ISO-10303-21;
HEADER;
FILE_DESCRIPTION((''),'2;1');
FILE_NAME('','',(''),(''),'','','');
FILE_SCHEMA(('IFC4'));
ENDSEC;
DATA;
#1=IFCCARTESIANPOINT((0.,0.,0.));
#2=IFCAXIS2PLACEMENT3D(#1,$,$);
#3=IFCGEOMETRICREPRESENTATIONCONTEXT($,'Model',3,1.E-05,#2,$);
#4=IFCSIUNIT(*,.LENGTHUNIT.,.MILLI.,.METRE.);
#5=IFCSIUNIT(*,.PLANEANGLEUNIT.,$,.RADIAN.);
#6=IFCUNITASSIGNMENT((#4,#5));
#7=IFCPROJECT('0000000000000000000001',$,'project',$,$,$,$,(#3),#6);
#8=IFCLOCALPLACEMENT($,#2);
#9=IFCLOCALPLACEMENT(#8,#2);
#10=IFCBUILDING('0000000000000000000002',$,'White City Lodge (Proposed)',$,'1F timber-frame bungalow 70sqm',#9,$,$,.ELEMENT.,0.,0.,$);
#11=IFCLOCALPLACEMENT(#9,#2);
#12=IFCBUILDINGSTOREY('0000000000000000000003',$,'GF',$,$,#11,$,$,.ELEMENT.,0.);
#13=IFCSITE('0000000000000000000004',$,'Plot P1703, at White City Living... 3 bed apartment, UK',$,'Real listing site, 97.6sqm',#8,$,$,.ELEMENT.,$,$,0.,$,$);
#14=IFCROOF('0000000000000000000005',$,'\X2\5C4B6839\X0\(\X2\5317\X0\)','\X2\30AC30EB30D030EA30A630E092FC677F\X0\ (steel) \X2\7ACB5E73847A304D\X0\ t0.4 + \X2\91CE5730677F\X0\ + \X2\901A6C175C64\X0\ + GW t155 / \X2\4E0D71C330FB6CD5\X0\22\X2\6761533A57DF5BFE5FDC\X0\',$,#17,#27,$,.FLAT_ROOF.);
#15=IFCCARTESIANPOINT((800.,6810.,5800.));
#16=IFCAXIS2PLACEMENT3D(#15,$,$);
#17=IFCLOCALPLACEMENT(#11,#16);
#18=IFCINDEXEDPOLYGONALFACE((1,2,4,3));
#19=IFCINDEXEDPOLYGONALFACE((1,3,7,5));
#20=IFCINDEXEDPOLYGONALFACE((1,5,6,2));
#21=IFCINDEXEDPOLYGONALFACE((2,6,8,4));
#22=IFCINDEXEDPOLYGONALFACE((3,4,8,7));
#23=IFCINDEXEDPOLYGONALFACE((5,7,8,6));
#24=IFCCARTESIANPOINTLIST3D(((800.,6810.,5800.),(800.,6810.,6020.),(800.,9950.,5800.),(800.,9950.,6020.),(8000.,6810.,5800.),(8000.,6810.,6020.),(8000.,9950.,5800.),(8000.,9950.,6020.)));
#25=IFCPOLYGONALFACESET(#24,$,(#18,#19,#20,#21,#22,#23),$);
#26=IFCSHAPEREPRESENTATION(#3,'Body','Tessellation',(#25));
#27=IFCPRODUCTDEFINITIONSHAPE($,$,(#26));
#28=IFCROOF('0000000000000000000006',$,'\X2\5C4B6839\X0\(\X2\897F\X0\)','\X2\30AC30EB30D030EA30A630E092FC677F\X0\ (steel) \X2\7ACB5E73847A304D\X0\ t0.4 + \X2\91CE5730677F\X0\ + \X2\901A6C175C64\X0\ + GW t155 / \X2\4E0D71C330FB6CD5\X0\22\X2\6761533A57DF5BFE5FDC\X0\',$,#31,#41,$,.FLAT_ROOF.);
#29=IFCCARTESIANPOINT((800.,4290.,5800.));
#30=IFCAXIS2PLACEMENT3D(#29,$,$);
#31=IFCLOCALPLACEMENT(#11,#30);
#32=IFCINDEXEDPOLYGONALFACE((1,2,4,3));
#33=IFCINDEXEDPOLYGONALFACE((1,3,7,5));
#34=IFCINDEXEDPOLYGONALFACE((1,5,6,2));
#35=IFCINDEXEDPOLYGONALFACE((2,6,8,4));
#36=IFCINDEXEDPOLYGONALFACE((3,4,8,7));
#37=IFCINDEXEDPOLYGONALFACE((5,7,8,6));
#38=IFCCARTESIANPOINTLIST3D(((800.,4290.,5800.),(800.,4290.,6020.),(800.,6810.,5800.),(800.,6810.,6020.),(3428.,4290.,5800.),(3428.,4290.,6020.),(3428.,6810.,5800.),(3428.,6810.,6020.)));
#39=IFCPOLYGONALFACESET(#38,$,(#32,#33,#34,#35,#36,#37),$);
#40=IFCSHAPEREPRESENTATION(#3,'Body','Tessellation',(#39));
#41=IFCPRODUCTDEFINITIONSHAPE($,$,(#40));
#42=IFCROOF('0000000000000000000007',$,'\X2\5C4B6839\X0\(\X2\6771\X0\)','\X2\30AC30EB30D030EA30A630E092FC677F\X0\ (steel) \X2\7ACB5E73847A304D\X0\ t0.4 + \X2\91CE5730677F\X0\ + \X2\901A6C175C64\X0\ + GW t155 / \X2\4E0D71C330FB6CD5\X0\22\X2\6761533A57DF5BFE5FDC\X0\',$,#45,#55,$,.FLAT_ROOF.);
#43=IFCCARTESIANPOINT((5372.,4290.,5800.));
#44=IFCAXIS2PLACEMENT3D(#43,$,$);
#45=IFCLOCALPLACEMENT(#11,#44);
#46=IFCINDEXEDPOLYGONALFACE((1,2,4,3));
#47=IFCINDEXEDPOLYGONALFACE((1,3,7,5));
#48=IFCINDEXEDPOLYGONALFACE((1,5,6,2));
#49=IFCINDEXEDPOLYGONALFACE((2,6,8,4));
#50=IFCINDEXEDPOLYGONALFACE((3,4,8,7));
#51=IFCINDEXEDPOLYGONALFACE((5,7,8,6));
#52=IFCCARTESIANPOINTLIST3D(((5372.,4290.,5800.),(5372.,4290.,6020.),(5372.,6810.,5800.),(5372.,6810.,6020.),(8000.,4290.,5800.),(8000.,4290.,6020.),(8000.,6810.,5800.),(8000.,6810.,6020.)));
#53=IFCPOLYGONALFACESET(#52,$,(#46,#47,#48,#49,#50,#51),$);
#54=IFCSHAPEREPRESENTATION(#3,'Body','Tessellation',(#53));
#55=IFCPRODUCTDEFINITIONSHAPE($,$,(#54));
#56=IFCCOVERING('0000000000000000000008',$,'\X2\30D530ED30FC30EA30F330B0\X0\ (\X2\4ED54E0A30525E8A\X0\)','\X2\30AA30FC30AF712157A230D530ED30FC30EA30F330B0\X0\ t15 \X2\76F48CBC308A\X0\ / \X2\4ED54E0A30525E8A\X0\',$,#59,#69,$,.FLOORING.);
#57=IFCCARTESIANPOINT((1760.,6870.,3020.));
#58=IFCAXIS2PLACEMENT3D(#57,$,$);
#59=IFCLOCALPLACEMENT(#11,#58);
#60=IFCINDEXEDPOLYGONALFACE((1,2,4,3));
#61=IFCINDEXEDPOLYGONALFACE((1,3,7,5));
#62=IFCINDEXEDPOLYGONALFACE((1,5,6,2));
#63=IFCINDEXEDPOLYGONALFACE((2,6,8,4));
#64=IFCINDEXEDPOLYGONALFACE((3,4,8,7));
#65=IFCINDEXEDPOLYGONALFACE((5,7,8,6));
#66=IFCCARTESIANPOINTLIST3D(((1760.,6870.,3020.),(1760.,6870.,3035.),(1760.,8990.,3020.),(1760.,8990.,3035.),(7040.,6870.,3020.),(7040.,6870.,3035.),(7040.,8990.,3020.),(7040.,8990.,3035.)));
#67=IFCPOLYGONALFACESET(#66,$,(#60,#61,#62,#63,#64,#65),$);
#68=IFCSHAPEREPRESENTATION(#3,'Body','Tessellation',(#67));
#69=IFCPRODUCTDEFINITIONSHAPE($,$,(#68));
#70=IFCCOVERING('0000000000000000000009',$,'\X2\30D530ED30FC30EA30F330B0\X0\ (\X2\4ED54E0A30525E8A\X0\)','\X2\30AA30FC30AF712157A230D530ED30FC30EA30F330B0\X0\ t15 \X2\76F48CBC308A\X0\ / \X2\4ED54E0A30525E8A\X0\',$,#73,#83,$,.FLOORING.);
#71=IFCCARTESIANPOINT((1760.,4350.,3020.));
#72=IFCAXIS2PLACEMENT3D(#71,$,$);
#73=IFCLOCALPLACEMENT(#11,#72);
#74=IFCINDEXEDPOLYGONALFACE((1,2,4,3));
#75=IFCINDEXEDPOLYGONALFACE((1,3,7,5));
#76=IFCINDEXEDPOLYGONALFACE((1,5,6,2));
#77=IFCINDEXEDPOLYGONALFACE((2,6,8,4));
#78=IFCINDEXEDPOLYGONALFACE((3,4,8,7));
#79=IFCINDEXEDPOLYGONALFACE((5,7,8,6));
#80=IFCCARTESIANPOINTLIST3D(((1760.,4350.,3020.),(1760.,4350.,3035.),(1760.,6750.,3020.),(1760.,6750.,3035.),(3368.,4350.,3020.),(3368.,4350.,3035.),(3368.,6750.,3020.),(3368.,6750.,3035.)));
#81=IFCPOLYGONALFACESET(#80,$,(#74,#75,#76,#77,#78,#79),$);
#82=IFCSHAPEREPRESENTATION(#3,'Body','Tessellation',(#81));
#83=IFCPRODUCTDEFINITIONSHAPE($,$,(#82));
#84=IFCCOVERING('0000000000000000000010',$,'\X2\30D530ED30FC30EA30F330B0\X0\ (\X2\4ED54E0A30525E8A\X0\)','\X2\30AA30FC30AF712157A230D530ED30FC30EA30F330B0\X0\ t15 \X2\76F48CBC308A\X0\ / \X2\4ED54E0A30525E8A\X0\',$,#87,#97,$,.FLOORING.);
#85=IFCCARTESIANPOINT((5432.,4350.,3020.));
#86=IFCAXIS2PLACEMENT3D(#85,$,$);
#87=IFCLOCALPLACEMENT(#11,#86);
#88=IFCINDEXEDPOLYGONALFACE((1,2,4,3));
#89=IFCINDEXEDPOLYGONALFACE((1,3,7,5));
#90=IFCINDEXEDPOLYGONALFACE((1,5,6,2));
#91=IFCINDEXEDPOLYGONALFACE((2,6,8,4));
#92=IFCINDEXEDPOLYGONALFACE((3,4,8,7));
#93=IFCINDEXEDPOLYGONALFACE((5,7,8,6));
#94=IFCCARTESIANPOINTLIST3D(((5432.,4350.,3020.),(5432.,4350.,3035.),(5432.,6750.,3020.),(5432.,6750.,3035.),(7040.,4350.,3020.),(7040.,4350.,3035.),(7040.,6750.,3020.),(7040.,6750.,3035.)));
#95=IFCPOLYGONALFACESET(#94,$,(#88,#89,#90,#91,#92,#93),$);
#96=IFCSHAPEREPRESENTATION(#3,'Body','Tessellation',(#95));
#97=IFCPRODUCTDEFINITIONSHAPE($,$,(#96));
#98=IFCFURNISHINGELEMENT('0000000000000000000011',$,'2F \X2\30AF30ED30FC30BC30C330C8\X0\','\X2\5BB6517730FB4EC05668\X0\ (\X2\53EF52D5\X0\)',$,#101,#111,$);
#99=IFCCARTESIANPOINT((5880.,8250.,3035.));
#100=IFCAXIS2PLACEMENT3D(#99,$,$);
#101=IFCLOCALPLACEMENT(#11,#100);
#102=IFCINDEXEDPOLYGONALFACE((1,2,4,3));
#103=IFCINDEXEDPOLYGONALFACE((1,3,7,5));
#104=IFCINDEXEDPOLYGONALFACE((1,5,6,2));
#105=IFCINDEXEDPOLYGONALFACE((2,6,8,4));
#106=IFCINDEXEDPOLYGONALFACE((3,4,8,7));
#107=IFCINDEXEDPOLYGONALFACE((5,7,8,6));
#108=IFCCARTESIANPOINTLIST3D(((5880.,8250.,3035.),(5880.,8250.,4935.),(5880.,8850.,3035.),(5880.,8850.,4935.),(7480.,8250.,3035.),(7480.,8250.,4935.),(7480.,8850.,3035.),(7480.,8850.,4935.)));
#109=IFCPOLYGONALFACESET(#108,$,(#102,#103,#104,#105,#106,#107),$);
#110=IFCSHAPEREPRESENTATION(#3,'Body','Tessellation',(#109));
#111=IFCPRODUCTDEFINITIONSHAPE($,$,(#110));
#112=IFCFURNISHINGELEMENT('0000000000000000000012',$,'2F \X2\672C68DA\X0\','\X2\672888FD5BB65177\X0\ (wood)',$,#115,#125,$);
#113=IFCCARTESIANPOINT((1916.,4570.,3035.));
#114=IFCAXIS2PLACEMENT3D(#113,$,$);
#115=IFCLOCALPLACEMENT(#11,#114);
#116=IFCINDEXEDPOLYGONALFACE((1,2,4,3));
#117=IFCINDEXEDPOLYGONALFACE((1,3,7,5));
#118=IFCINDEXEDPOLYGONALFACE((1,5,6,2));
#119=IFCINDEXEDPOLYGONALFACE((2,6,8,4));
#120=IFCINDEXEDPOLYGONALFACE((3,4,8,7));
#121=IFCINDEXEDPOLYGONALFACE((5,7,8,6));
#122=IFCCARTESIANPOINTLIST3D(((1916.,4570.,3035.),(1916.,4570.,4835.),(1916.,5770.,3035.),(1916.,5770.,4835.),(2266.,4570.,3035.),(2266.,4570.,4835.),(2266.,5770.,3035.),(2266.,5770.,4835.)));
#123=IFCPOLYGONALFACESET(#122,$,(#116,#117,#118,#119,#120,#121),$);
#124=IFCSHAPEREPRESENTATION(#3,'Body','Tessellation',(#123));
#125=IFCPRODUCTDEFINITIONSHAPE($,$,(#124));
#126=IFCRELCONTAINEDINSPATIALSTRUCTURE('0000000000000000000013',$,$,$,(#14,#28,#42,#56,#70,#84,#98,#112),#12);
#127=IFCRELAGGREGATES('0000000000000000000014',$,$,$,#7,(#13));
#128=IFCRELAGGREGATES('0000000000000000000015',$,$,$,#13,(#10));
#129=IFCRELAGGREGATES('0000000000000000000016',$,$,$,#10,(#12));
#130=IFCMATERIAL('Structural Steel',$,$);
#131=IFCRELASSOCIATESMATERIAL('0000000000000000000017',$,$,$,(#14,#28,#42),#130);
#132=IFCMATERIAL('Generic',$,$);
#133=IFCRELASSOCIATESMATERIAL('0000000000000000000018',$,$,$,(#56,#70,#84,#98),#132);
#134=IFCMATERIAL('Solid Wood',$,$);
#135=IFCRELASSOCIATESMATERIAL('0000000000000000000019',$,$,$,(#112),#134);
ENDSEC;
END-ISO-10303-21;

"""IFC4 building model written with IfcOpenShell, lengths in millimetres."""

from ifc_helpers import new_model, si_unit, frame, frame_2d, origin, place, context, project, spatial, rectangle, extrude, material, element, save


model = new_model("IFC4")

# Units and contexts
model_context = context("Model", 3, precision=1e-05, world=origin())
ifc_project = project(units=[si_unit("LENGTHUNIT", "METRE", prefix="MILLI"), si_unit("PLANEANGLEUNIT", "RADIAN")], contexts=[model_context])

# Site, building, storey
site_placement = place(None, origin())
site = spatial("IfcSite", under=ifc_project, at=site_placement, Name="Plot P1703, at White City Living... 3 bed apartment, UK", ObjectType="Real listing site, 97.6sqm", CompositionType="ELEMENT", RefElevation=0.0)
building_placement = place(site_placement, origin())
building = spatial("IfcBuilding", under=site, at=building_placement, Name="White City Lodge (Proposed)", ObjectType="1F timber-frame bungalow 70sqm", CompositionType="ELEMENT", ElevationOfRefHeight=0.0, ElevationOfTerrain=0.0)
storey_placement = place(building_placement, origin())
storey = spatial("IfcBuildingStorey", under=building, at=storey_placement, Name="GF", CompositionType="ELEMENT", Elevation=0.0)

# Shared definitions
ifc_material_1 = material(Name="Solid Wood")

# Shared definitions
ifc_material_2 = material(Name="Generic")

# Roofs
ifc_material_3 = material(Name="Structural Steel")
for number, where, name in (
    (1, (800.0, 6810.0, 5800.0), "屋根(北)"),
):
    element("IfcRoof", number, at=place(storey_placement, frame(where)), inside=storey, material=ifc_material_3, Name=name, Description="ガルバリウム鋼板 (steel) 立平葺き t0.4 + 野地板 + 通気層 + GW t155 / 不燃・法22条区域対応", PredefinedType="FLAT_ROOF", context=model_context, shape_type="SweptSolid", body=[
        extrude(rectangle(XDim=7200.0, YDim=3140.0, at=frame_2d((3600.0, 1570.0))), frame((800.0, 6810.0, 5800.0)), (0.0, 0.0, 1.0), 220.0),
    ])
roof_1_placement = place(storey_placement, frame((800.0, 4290.0, 5800.0)))
element("IfcRoof", 2, at=roof_1_placement, inside=storey, material=ifc_material_3, Name="屋根(西)", Description="ガルバリウム鋼板 (steel) 立平葺き t0.4 + 野地板 + 通気層 + GW t155 / 不燃・法22条区域対応", PredefinedType="FLAT_ROOF", context=model_context, shape_type="SweptSolid", body=[
    extrude(rectangle(XDim=2628.0, YDim=2520.0, at=frame_2d((1314.0, 1260.0))), frame((800.0, 4290.0, 5800.0)), (0.0, 0.0, 1.0), 220.0),
])
roof_2_placement = place(storey_placement, frame((5372.0, 4290.0, 5800.0)))
element("IfcRoof", 3, at=roof_2_placement, inside=storey, material=ifc_material_3, Name="屋根(東)", Description="ガルバリウム鋼板 (steel) 立平葺き t0.4 + 野地板 + 通気層 + GW t155 / 不燃・法22条区域対応", PredefinedType="FLAT_ROOF", context=model_context, shape_type="SweptSolid", body=[
    extrude(rectangle(XDim=2628.0, YDim=2520.0, at=frame_2d((1314.0, 1260.0))), frame((5372.0, 4290.0, 5800.0)), (0.0, 0.0, 1.0), 220.0),
])

# Coverings
covering_1_placement = place(storey_placement, frame((1760.0, 6870.0, 3020.0)))
element("IfcCovering", 4, at=covering_1_placement, inside=storey, material=ifc_material_2, Name="フローリング (仕上げ床)", Description="オーク無垢フローリング t15 直貼り / 仕上げ床", PredefinedType="FLOORING", context=model_context, shape_type="SweptSolid", body=[
    extrude(rectangle(XDim=5280.0, YDim=2120.0, at=frame_2d((2640.0, 1060.0))), frame((1760.0, 6870.0, 3020.0)), (0.0, 0.0, 1.0), 15.0),
])
covering_2_placement = place(storey_placement, frame((1760.0, 4350.0, 3020.0)))
element("IfcCovering", 5, at=covering_2_placement, inside=storey, material=ifc_material_2, Name="フローリング (仕上げ床)", Description="オーク無垢フローリング t15 直貼り / 仕上げ床", PredefinedType="FLOORING", context=model_context, shape_type="SweptSolid", body=[
    extrude(rectangle(XDim=1608.0, YDim=2400.0, at=frame_2d((804.0, 1200.0))), frame((1760.0, 4350.0, 3020.0)), (0.0, 0.0, 1.0), 15.0),
])
covering_3_placement = place(storey_placement, frame((5432.0, 4350.0, 3020.0)))
element("IfcCovering", 6, at=covering_3_placement, inside=storey, material=ifc_material_2, Name="フローリング (仕上げ床)", Description="オーク無垢フローリング t15 直貼り / 仕上げ床", PredefinedType="FLOORING", context=model_context, shape_type="SweptSolid", body=[
    extrude(rectangle(XDim=1608.0, YDim=2400.0, at=frame_2d((804.0, 1200.0))), frame((5432.0, 4350.0, 3020.0)), (0.0, 0.0, 1.0), 15.0),
])

# Furnishing elements
furnishing_1_placement = place(storey_placement, frame((5880.0, 8250.0, 3035.0)))
element("IfcFurnishingElement", 7, at=furnishing_1_placement, inside=storey, material=ifc_material_2, Name="2F クローゼット", Description="家具・什器 (可動)", context=model_context, shape_type="SweptSolid", body=[
    extrude(rectangle(XDim=1600.0, YDim=600.0, at=frame_2d((800.0, 300.0))), frame((5880.0, 8250.0, 3035.0)), (0.0, 0.0, 1.0), 1900.0),
])
furnishing_2_placement = place(storey_placement, frame((1916.0, 4570.0, 3035.0)))
element("IfcFurnishingElement", 8, at=furnishing_2_placement, inside=storey, material=ifc_material_1, Name="2F 本棚", Description="木製家具 (wood)", context=model_context, shape_type="SweptSolid", body=[
    extrude(rectangle(XDim=350.0, YDim=1200.0, at=frame_2d((175.0, 600.0))), frame((1916.0, 4570.0, 3035.0)), (0.0, 0.0, 1.0), 1800.0),
])

save(model, "model.ifc")
